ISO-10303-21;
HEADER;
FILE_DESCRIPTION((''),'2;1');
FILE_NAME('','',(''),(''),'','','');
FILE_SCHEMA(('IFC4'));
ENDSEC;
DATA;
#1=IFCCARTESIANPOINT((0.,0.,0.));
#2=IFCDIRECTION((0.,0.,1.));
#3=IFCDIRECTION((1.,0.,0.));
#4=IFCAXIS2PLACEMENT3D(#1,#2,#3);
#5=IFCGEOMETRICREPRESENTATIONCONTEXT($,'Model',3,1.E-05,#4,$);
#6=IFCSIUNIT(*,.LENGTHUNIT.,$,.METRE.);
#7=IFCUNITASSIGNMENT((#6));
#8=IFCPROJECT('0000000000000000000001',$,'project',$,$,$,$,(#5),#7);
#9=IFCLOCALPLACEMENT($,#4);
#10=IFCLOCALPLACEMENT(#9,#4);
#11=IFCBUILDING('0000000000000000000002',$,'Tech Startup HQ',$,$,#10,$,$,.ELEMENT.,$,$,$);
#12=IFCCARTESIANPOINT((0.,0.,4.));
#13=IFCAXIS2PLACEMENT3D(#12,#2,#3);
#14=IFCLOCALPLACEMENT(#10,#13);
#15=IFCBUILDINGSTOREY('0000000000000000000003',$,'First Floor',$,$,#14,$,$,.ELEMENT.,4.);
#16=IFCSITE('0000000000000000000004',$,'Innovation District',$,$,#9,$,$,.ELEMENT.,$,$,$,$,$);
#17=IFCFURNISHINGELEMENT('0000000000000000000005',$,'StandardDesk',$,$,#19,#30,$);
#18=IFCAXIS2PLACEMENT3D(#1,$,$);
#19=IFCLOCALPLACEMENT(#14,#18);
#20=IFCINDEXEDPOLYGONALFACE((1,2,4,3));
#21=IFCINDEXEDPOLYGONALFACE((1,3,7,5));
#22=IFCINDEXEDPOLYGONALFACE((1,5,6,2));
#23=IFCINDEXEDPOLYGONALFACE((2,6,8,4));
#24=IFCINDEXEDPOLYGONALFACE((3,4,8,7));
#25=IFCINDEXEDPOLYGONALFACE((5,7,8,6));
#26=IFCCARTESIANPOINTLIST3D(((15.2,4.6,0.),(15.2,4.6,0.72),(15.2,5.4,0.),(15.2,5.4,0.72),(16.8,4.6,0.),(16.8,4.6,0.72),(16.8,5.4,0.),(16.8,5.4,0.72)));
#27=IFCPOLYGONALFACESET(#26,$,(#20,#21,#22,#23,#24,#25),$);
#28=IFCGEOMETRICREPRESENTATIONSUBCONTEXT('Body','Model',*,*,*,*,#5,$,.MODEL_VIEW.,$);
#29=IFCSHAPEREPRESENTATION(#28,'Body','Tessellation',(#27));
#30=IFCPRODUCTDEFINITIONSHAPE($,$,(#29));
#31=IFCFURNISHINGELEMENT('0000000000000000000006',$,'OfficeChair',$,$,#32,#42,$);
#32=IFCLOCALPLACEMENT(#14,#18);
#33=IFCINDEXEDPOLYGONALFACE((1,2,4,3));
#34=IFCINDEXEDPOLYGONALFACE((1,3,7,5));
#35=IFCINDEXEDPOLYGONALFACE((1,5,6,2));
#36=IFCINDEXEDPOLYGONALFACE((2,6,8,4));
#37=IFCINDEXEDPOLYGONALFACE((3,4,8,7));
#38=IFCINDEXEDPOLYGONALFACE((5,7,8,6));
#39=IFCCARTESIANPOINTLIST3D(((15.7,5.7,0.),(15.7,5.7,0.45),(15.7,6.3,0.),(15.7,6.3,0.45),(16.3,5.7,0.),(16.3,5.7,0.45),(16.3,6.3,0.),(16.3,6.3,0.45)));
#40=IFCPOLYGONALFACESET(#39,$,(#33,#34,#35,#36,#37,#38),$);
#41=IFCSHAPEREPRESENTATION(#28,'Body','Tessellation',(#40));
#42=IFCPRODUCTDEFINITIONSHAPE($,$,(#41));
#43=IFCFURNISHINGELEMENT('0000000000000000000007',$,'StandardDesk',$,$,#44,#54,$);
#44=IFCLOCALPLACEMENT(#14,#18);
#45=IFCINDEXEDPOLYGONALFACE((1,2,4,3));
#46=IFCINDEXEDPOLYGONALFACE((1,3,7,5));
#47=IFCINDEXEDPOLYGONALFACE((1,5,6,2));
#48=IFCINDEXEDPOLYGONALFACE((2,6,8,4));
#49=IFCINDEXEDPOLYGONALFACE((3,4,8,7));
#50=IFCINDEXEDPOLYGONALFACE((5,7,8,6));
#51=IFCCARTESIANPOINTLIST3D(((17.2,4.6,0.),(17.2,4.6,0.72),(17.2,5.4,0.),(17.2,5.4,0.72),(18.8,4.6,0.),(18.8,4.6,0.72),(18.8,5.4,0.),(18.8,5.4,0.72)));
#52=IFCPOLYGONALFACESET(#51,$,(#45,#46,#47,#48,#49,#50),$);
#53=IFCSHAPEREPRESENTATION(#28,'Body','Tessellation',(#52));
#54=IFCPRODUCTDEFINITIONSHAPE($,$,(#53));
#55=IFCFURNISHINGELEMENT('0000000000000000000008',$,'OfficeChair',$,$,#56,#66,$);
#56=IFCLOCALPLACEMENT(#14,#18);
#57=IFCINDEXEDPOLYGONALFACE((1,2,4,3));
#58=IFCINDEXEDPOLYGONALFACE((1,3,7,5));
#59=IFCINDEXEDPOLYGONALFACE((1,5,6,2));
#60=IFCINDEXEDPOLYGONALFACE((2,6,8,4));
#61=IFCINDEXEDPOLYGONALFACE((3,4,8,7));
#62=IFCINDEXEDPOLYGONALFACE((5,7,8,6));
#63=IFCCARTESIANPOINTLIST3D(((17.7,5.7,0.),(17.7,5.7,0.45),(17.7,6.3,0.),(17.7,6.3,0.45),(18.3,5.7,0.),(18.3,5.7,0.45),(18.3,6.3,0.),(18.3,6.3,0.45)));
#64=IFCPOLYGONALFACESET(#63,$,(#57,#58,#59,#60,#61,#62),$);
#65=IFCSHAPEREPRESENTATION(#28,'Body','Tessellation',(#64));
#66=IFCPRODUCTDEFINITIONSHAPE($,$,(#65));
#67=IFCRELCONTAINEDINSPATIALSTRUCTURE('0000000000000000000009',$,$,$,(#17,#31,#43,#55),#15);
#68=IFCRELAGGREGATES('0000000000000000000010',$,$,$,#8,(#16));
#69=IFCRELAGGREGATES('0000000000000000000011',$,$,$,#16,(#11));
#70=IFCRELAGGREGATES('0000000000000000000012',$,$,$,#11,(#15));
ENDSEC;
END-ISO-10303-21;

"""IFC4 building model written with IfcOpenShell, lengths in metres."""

from ifc_helpers import new_model, si_unit, frame, origin_with_axes, place, context, subcontext, project, spatial, polyline, outline, extrude, element, save


model = new_model("IFC4")

# Units and contexts
model_context = context("Model", 3, precision=1e-05, world=origin_with_axes())
body_context = subcontext(model_context, "Body", "Model", "MODEL_VIEW")
ifc_project = project(units=[si_unit("LENGTHUNIT", "METRE")], contexts=[model_context])

# Site, building, storey
site_placement = place(None, origin_with_axes())
site = spatial("IfcSite", under=ifc_project, at=site_placement, Name="Innovation District", CompositionType="ELEMENT")
building_placement = place(site_placement, origin_with_axes())
building = spatial("IfcBuilding", under=site, at=building_placement, Name="Tech Startup HQ", CompositionType="ELEMENT")
storey_placement = place(building_placement, frame((0.0, 0.0, 4.0), z_axis=(0.0, 0.0, 1.0), x_axis=(1.0, 0.0, 0.0)))
storey = spatial("IfcBuildingStorey", under=building, at=storey_placement, Name="First Floor", CompositionType="ELEMENT", Elevation=4.0)

# Furnishing elements
furnishing_1_placement = place(storey_placement, origin_with_axes())
element("IfcFurnishingElement", 1, at=furnishing_1_placement, inside=storey, Name="StandardDesk", context=body_context, shape_type="SweptSolid", body=[
    extrude(outline(polyline([(15.2, 4.6, 0.0), (16.8, 4.6, 0.0), (16.8, 5.4, 0.0), (15.2, 5.4, 0.0), (15.2, 4.6, 0.0)])), None, (0.0, 0.0, 1.0), 0.72),
])
furnishing_2_placement = place(storey_placement, origin_with_axes())
element("IfcFurnishingElement", 2, at=furnishing_2_placement, inside=storey, Name="OfficeChair", context=body_context, shape_type="SweptSolid", body=[
    extrude(outline(polyline([(16.3, 6.3, 0.0), (15.7, 6.3, 0.0), (15.7, 5.7, 0.0), (16.3, 5.7, 0.0), (16.3, 6.3, 0.0)])), None, (0.0, 0.0, 1.0), 0.45),
])
furnishing_3_placement = place(storey_placement, origin_with_axes())
element("IfcFurnishingElement", 3, at=furnishing_3_placement, inside=storey, Name="StandardDesk", context=body_context, shape_type="SweptSolid", body=[
    extrude(outline(polyline([(17.2, 4.6, 0.0), (18.8, 4.6, 0.0), (18.8, 5.4, 0.0), (17.2, 5.4, 0.0), (17.2, 4.6, 0.0)])), None, (0.0, 0.0, 1.0), 0.72),
])
furnishing_4_placement = place(storey_placement, origin_with_axes())
element("IfcFurnishingElement", 4, at=furnishing_4_placement, inside=storey, Name="OfficeChair", context=body_context, shape_type="SweptSolid", body=[
    extrude(outline(polyline([(18.3, 6.3, 0.0), (17.7, 6.3, 0.0), (17.7, 5.7, 0.0), (18.3, 5.7, 0.0), (18.3, 6.3, 0.0)])), None, (0.0, 0.0, 1.0), 0.45),
])

save(model, "model.ifc")
